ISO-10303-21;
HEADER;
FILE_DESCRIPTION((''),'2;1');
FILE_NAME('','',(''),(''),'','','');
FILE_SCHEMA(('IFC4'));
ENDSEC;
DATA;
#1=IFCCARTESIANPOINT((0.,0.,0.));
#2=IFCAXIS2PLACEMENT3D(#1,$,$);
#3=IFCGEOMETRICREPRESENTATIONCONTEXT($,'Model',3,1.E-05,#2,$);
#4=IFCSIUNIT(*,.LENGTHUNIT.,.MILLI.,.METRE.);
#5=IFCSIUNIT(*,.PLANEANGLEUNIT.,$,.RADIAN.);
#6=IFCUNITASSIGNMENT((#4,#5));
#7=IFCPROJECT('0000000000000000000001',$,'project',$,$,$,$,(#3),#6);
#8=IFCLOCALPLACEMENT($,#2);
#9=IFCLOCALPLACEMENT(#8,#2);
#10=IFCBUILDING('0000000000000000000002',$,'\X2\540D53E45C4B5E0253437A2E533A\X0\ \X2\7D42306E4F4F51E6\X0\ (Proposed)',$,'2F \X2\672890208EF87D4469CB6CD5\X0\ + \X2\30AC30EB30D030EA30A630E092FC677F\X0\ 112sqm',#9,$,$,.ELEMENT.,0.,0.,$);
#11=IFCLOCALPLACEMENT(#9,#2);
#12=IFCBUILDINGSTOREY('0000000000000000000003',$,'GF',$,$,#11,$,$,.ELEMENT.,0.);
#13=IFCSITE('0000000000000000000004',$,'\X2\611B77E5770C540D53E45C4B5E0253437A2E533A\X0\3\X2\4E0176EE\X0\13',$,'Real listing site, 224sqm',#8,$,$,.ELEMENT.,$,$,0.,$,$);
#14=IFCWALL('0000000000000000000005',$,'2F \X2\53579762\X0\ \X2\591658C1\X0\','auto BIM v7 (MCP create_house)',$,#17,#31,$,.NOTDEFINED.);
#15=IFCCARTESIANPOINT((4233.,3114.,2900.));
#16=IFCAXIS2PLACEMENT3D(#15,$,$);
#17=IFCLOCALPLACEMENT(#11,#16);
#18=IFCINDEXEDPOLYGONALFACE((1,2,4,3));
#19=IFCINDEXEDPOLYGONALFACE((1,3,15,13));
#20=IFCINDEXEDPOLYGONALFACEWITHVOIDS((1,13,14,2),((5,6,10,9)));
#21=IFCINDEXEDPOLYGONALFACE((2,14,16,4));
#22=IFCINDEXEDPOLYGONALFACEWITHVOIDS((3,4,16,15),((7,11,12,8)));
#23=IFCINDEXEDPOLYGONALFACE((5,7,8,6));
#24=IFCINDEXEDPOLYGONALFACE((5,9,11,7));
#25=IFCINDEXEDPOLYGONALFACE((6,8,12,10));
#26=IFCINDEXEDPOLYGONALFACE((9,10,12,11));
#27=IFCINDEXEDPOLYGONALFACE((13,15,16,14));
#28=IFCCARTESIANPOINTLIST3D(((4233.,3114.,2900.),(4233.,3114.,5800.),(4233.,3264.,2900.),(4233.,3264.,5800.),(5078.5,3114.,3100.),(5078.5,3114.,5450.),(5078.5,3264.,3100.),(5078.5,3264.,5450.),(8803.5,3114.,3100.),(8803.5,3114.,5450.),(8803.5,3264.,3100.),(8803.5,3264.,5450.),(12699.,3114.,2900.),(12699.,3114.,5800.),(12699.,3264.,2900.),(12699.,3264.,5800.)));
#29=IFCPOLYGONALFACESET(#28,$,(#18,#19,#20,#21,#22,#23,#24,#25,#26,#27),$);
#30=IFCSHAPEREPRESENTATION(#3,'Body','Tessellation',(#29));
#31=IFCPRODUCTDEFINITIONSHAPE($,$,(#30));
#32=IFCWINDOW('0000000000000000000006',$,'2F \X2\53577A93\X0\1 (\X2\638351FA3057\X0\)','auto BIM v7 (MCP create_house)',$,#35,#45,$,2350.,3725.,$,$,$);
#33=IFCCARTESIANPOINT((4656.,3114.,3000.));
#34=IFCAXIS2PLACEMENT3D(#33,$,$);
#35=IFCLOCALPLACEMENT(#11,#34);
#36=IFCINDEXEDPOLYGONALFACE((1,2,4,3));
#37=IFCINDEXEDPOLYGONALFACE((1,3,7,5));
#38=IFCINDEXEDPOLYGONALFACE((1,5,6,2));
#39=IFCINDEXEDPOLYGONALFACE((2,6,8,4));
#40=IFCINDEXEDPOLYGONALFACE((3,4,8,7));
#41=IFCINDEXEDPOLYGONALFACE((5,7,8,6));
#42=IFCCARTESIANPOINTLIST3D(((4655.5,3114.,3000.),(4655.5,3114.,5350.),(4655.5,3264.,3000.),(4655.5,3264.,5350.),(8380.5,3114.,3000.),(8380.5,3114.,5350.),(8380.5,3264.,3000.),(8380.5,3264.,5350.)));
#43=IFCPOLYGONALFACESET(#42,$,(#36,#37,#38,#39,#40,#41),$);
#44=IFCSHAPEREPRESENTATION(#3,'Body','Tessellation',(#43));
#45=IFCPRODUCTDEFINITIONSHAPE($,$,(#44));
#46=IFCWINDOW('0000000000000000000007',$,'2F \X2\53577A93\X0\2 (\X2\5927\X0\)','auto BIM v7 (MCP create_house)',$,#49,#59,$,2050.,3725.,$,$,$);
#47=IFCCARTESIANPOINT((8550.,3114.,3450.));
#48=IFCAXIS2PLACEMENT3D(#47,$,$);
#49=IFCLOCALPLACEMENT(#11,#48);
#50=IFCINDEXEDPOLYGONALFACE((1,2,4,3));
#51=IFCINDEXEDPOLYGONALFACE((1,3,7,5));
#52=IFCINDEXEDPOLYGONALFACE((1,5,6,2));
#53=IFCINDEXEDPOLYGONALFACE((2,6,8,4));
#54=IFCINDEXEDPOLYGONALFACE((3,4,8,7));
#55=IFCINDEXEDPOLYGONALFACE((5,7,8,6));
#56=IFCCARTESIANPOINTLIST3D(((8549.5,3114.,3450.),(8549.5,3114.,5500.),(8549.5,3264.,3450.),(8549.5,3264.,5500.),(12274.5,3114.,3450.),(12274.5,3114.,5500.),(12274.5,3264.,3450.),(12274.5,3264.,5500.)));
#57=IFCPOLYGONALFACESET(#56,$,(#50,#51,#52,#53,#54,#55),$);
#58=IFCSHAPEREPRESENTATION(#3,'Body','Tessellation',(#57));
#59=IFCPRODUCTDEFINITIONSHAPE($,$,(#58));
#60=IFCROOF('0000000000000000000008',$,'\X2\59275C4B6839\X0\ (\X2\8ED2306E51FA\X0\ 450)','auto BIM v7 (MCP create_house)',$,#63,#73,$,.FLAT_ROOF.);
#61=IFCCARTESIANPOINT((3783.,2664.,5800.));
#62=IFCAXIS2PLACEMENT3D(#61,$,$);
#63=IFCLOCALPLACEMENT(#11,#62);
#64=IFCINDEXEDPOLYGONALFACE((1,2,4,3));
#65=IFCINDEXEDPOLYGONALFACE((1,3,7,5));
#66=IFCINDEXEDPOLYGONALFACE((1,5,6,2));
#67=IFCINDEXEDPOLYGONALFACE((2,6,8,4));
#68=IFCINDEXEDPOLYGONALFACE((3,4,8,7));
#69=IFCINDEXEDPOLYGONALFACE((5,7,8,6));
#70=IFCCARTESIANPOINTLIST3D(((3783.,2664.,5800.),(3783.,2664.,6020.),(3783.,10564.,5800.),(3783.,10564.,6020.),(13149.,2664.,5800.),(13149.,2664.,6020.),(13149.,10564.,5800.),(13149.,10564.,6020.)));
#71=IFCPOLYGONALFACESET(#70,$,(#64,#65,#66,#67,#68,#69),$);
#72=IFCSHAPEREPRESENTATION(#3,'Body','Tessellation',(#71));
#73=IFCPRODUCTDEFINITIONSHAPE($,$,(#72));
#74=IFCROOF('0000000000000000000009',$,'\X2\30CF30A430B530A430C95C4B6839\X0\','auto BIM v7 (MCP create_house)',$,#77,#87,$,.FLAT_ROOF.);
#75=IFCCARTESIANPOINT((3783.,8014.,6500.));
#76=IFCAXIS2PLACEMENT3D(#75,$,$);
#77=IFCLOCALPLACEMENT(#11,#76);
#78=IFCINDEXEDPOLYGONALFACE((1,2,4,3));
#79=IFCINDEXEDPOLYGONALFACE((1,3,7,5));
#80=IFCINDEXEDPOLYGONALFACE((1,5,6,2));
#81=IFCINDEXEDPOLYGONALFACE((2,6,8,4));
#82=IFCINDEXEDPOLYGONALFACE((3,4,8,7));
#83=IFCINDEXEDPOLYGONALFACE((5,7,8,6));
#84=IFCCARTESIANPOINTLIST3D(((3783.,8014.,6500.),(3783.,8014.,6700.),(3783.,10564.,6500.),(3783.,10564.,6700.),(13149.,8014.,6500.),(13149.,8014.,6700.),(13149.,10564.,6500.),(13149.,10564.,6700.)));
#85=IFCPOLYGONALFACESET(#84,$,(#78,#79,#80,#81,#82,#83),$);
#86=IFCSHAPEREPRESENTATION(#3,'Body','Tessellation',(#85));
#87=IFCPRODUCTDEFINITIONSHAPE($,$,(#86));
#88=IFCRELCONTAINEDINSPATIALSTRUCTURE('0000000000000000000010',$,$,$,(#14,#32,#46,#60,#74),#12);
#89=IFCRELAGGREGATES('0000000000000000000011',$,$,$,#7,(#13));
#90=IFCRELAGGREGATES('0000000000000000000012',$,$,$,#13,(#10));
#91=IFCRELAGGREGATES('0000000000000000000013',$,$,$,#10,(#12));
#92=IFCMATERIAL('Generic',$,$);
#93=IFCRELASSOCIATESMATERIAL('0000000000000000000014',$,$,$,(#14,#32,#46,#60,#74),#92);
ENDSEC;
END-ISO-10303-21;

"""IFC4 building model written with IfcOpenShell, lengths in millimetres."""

from ifc_helpers import new_model, si_unit, frame, frame_2d, origin, place, context, project, spatial, rectangle, extrude, material, element, fill, save


model = new_model("IFC4")

# Units and contexts
model_context = context("Model", 3, precision=1e-05, world=origin())
ifc_project = project(units=[si_unit("LENGTHUNIT", "METRE", prefix="MILLI"), si_unit("PLANEANGLEUNIT", "RADIAN")], contexts=[model_context])

# Site, building, storey
site_placement = place(None, origin())
site = spatial("IfcSite", under=ifc_project, at=site_placement, Name="愛知県名古屋市千種区3丁目13", ObjectType="Real listing site, 224sqm", CompositionType="ELEMENT", RefElevation=0.0)
building_placement = place(site_placement, origin())
building = spatial("IfcBuilding", under=site, at=building_placement, Name="名古屋市千種区 終の住処 (Proposed)", ObjectType="2F 木造軸組構法 + ガルバリウム鋼板 112sqm", CompositionType="ELEMENT", ElevationOfRefHeight=0.0, ElevationOfTerrain=0.0)
storey_placement = place(building_placement, origin())
storey = spatial("IfcBuildingStorey", under=building, at=storey_placement, Name="GF", CompositionType="ELEMENT", Elevation=0.0)

# Shared definitions
ifc_material = material(Name="Generic")

# Wall, openings, windows
wall_1_placement = place(storey_placement, frame((4233.0, 3114.0, 2900.0)))
wall_1 = element("IfcWall", 1, at=wall_1_placement, inside=storey, material=ifc_material, Name="2F 南面 外壁", Description="auto BIM v7 (MCP create_house)", PredefinedType="NOTDEFINED", context=model_context, shape_type="SweptSolid", body=[
    extrude(rectangle(XDim=8466.0, YDim=150.0, at=frame_2d((4233.0, 75.0))), frame((4233.0, 3114.0, 2900.0)), (0.0, 0.0, 1.0), 2900.0),
])
opening_1_placement = place(storey_placement, frame((4656.0, 3114.0, 3000.0)))
opening_1 = element("IfcOpeningElement", 2, at=opening_1_placement, cuts=wall_1, PredefinedType="NOTDEFINED", context=model_context, shape_type="SweptSolid", body=[
    extrude(rectangle(XDim=3725.0, YDim=150.0, at=frame_2d((1862.0, 75.0))), frame((4656.0, 3114.0, 3000.0)), (0.0, 0.0, 1.0), 2350.0),
])
opening_2_placement = place(storey_placement, frame((8550.0, 3114.0, 3450.0)))
opening_2 = element("IfcOpeningElement", 3, at=opening_2_placement, cuts=wall_1, PredefinedType="NOTDEFINED", context=model_context, shape_type="SweptSolid", body=[
    extrude(rectangle(XDim=3725.0, YDim=150.0, at=frame_2d((1862.0, 75.0))), frame((8550.0, 3114.0, 3450.0)), (0.0, 0.0, 1.0), 2050.0),
])
window_1_placement = place(storey_placement, frame((4656.0, 3114.0, 3000.0)))
window_1 = element("IfcWindow", 4, at=window_1_placement, inside=storey, material=ifc_material, Name="2F 南窓1 (掃出し)", Description="auto BIM v7 (MCP create_house)", OverallHeight=2350.0, OverallWidth=3725.0, context=model_context, shape_type="SweptSolid", body=[
    extrude(rectangle(XDim=3725.0, YDim=150.0, at=frame_2d((1862.0, 75.0))), frame((4656.0, 3114.0, 3000.0)), (0.0, 0.0, 1.0), 2350.0),
])
fill(opening_1, window_1)
window_2_placement = place(storey_placement, frame((8550.0, 3114.0, 3450.0)))
window_2 = element("IfcWindow", 5, at=window_2_placement, inside=storey, material=ifc_material, Name="2F 南窓2 (大)", Description="auto BIM v7 (MCP create_house)", OverallHeight=2050.0, OverallWidth=3725.0, context=model_context, shape_type="SweptSolid", body=[
    extrude(rectangle(XDim=3725.0, YDim=150.0, at=frame_2d((1862.0, 75.0))), frame((8550.0, 3114.0, 3450.0)), (0.0, 0.0, 1.0), 2050.0),
])
fill(opening_2, window_2)

# Roofs
roof_1_placement = place(storey_placement, frame((3783.0, 2664.0, 5800.0)))
element("IfcRoof", 6, at=roof_1_placement, inside=storey, material=ifc_material, Name="大屋根 (軒の出 450)", Description="auto BIM v7 (MCP create_house)", PredefinedType="FLAT_ROOF", context=model_context, shape_type="SweptSolid", body=[
    extrude(rectangle(XDim=9366.0, YDim=7900.0, at=frame_2d((4683.0, 3950.0))), frame((3783.0, 2664.0, 5800.0)), (0.0, 0.0, 1.0), 220.0),
])
roof_2_placement = place(storey_placement, frame((3783.0, 8014.0, 6500.0)))
element("IfcRoof", 7, at=roof_2_placement, inside=storey, material=ifc_material, Name="ハイサイド屋根", Description="auto BIM v7 (MCP create_house)", PredefinedType="FLAT_ROOF", context=model_context, shape_type="SweptSolid", body=[
    extrude(rectangle(XDim=9366.0, YDim=2550.0, at=frame_2d((4683.0, 1275.0))), frame((3783.0, 8014.0, 6500.0)), (0.0, 0.0, 1.0), 200.0),
])

save(model, "model.ifc")
